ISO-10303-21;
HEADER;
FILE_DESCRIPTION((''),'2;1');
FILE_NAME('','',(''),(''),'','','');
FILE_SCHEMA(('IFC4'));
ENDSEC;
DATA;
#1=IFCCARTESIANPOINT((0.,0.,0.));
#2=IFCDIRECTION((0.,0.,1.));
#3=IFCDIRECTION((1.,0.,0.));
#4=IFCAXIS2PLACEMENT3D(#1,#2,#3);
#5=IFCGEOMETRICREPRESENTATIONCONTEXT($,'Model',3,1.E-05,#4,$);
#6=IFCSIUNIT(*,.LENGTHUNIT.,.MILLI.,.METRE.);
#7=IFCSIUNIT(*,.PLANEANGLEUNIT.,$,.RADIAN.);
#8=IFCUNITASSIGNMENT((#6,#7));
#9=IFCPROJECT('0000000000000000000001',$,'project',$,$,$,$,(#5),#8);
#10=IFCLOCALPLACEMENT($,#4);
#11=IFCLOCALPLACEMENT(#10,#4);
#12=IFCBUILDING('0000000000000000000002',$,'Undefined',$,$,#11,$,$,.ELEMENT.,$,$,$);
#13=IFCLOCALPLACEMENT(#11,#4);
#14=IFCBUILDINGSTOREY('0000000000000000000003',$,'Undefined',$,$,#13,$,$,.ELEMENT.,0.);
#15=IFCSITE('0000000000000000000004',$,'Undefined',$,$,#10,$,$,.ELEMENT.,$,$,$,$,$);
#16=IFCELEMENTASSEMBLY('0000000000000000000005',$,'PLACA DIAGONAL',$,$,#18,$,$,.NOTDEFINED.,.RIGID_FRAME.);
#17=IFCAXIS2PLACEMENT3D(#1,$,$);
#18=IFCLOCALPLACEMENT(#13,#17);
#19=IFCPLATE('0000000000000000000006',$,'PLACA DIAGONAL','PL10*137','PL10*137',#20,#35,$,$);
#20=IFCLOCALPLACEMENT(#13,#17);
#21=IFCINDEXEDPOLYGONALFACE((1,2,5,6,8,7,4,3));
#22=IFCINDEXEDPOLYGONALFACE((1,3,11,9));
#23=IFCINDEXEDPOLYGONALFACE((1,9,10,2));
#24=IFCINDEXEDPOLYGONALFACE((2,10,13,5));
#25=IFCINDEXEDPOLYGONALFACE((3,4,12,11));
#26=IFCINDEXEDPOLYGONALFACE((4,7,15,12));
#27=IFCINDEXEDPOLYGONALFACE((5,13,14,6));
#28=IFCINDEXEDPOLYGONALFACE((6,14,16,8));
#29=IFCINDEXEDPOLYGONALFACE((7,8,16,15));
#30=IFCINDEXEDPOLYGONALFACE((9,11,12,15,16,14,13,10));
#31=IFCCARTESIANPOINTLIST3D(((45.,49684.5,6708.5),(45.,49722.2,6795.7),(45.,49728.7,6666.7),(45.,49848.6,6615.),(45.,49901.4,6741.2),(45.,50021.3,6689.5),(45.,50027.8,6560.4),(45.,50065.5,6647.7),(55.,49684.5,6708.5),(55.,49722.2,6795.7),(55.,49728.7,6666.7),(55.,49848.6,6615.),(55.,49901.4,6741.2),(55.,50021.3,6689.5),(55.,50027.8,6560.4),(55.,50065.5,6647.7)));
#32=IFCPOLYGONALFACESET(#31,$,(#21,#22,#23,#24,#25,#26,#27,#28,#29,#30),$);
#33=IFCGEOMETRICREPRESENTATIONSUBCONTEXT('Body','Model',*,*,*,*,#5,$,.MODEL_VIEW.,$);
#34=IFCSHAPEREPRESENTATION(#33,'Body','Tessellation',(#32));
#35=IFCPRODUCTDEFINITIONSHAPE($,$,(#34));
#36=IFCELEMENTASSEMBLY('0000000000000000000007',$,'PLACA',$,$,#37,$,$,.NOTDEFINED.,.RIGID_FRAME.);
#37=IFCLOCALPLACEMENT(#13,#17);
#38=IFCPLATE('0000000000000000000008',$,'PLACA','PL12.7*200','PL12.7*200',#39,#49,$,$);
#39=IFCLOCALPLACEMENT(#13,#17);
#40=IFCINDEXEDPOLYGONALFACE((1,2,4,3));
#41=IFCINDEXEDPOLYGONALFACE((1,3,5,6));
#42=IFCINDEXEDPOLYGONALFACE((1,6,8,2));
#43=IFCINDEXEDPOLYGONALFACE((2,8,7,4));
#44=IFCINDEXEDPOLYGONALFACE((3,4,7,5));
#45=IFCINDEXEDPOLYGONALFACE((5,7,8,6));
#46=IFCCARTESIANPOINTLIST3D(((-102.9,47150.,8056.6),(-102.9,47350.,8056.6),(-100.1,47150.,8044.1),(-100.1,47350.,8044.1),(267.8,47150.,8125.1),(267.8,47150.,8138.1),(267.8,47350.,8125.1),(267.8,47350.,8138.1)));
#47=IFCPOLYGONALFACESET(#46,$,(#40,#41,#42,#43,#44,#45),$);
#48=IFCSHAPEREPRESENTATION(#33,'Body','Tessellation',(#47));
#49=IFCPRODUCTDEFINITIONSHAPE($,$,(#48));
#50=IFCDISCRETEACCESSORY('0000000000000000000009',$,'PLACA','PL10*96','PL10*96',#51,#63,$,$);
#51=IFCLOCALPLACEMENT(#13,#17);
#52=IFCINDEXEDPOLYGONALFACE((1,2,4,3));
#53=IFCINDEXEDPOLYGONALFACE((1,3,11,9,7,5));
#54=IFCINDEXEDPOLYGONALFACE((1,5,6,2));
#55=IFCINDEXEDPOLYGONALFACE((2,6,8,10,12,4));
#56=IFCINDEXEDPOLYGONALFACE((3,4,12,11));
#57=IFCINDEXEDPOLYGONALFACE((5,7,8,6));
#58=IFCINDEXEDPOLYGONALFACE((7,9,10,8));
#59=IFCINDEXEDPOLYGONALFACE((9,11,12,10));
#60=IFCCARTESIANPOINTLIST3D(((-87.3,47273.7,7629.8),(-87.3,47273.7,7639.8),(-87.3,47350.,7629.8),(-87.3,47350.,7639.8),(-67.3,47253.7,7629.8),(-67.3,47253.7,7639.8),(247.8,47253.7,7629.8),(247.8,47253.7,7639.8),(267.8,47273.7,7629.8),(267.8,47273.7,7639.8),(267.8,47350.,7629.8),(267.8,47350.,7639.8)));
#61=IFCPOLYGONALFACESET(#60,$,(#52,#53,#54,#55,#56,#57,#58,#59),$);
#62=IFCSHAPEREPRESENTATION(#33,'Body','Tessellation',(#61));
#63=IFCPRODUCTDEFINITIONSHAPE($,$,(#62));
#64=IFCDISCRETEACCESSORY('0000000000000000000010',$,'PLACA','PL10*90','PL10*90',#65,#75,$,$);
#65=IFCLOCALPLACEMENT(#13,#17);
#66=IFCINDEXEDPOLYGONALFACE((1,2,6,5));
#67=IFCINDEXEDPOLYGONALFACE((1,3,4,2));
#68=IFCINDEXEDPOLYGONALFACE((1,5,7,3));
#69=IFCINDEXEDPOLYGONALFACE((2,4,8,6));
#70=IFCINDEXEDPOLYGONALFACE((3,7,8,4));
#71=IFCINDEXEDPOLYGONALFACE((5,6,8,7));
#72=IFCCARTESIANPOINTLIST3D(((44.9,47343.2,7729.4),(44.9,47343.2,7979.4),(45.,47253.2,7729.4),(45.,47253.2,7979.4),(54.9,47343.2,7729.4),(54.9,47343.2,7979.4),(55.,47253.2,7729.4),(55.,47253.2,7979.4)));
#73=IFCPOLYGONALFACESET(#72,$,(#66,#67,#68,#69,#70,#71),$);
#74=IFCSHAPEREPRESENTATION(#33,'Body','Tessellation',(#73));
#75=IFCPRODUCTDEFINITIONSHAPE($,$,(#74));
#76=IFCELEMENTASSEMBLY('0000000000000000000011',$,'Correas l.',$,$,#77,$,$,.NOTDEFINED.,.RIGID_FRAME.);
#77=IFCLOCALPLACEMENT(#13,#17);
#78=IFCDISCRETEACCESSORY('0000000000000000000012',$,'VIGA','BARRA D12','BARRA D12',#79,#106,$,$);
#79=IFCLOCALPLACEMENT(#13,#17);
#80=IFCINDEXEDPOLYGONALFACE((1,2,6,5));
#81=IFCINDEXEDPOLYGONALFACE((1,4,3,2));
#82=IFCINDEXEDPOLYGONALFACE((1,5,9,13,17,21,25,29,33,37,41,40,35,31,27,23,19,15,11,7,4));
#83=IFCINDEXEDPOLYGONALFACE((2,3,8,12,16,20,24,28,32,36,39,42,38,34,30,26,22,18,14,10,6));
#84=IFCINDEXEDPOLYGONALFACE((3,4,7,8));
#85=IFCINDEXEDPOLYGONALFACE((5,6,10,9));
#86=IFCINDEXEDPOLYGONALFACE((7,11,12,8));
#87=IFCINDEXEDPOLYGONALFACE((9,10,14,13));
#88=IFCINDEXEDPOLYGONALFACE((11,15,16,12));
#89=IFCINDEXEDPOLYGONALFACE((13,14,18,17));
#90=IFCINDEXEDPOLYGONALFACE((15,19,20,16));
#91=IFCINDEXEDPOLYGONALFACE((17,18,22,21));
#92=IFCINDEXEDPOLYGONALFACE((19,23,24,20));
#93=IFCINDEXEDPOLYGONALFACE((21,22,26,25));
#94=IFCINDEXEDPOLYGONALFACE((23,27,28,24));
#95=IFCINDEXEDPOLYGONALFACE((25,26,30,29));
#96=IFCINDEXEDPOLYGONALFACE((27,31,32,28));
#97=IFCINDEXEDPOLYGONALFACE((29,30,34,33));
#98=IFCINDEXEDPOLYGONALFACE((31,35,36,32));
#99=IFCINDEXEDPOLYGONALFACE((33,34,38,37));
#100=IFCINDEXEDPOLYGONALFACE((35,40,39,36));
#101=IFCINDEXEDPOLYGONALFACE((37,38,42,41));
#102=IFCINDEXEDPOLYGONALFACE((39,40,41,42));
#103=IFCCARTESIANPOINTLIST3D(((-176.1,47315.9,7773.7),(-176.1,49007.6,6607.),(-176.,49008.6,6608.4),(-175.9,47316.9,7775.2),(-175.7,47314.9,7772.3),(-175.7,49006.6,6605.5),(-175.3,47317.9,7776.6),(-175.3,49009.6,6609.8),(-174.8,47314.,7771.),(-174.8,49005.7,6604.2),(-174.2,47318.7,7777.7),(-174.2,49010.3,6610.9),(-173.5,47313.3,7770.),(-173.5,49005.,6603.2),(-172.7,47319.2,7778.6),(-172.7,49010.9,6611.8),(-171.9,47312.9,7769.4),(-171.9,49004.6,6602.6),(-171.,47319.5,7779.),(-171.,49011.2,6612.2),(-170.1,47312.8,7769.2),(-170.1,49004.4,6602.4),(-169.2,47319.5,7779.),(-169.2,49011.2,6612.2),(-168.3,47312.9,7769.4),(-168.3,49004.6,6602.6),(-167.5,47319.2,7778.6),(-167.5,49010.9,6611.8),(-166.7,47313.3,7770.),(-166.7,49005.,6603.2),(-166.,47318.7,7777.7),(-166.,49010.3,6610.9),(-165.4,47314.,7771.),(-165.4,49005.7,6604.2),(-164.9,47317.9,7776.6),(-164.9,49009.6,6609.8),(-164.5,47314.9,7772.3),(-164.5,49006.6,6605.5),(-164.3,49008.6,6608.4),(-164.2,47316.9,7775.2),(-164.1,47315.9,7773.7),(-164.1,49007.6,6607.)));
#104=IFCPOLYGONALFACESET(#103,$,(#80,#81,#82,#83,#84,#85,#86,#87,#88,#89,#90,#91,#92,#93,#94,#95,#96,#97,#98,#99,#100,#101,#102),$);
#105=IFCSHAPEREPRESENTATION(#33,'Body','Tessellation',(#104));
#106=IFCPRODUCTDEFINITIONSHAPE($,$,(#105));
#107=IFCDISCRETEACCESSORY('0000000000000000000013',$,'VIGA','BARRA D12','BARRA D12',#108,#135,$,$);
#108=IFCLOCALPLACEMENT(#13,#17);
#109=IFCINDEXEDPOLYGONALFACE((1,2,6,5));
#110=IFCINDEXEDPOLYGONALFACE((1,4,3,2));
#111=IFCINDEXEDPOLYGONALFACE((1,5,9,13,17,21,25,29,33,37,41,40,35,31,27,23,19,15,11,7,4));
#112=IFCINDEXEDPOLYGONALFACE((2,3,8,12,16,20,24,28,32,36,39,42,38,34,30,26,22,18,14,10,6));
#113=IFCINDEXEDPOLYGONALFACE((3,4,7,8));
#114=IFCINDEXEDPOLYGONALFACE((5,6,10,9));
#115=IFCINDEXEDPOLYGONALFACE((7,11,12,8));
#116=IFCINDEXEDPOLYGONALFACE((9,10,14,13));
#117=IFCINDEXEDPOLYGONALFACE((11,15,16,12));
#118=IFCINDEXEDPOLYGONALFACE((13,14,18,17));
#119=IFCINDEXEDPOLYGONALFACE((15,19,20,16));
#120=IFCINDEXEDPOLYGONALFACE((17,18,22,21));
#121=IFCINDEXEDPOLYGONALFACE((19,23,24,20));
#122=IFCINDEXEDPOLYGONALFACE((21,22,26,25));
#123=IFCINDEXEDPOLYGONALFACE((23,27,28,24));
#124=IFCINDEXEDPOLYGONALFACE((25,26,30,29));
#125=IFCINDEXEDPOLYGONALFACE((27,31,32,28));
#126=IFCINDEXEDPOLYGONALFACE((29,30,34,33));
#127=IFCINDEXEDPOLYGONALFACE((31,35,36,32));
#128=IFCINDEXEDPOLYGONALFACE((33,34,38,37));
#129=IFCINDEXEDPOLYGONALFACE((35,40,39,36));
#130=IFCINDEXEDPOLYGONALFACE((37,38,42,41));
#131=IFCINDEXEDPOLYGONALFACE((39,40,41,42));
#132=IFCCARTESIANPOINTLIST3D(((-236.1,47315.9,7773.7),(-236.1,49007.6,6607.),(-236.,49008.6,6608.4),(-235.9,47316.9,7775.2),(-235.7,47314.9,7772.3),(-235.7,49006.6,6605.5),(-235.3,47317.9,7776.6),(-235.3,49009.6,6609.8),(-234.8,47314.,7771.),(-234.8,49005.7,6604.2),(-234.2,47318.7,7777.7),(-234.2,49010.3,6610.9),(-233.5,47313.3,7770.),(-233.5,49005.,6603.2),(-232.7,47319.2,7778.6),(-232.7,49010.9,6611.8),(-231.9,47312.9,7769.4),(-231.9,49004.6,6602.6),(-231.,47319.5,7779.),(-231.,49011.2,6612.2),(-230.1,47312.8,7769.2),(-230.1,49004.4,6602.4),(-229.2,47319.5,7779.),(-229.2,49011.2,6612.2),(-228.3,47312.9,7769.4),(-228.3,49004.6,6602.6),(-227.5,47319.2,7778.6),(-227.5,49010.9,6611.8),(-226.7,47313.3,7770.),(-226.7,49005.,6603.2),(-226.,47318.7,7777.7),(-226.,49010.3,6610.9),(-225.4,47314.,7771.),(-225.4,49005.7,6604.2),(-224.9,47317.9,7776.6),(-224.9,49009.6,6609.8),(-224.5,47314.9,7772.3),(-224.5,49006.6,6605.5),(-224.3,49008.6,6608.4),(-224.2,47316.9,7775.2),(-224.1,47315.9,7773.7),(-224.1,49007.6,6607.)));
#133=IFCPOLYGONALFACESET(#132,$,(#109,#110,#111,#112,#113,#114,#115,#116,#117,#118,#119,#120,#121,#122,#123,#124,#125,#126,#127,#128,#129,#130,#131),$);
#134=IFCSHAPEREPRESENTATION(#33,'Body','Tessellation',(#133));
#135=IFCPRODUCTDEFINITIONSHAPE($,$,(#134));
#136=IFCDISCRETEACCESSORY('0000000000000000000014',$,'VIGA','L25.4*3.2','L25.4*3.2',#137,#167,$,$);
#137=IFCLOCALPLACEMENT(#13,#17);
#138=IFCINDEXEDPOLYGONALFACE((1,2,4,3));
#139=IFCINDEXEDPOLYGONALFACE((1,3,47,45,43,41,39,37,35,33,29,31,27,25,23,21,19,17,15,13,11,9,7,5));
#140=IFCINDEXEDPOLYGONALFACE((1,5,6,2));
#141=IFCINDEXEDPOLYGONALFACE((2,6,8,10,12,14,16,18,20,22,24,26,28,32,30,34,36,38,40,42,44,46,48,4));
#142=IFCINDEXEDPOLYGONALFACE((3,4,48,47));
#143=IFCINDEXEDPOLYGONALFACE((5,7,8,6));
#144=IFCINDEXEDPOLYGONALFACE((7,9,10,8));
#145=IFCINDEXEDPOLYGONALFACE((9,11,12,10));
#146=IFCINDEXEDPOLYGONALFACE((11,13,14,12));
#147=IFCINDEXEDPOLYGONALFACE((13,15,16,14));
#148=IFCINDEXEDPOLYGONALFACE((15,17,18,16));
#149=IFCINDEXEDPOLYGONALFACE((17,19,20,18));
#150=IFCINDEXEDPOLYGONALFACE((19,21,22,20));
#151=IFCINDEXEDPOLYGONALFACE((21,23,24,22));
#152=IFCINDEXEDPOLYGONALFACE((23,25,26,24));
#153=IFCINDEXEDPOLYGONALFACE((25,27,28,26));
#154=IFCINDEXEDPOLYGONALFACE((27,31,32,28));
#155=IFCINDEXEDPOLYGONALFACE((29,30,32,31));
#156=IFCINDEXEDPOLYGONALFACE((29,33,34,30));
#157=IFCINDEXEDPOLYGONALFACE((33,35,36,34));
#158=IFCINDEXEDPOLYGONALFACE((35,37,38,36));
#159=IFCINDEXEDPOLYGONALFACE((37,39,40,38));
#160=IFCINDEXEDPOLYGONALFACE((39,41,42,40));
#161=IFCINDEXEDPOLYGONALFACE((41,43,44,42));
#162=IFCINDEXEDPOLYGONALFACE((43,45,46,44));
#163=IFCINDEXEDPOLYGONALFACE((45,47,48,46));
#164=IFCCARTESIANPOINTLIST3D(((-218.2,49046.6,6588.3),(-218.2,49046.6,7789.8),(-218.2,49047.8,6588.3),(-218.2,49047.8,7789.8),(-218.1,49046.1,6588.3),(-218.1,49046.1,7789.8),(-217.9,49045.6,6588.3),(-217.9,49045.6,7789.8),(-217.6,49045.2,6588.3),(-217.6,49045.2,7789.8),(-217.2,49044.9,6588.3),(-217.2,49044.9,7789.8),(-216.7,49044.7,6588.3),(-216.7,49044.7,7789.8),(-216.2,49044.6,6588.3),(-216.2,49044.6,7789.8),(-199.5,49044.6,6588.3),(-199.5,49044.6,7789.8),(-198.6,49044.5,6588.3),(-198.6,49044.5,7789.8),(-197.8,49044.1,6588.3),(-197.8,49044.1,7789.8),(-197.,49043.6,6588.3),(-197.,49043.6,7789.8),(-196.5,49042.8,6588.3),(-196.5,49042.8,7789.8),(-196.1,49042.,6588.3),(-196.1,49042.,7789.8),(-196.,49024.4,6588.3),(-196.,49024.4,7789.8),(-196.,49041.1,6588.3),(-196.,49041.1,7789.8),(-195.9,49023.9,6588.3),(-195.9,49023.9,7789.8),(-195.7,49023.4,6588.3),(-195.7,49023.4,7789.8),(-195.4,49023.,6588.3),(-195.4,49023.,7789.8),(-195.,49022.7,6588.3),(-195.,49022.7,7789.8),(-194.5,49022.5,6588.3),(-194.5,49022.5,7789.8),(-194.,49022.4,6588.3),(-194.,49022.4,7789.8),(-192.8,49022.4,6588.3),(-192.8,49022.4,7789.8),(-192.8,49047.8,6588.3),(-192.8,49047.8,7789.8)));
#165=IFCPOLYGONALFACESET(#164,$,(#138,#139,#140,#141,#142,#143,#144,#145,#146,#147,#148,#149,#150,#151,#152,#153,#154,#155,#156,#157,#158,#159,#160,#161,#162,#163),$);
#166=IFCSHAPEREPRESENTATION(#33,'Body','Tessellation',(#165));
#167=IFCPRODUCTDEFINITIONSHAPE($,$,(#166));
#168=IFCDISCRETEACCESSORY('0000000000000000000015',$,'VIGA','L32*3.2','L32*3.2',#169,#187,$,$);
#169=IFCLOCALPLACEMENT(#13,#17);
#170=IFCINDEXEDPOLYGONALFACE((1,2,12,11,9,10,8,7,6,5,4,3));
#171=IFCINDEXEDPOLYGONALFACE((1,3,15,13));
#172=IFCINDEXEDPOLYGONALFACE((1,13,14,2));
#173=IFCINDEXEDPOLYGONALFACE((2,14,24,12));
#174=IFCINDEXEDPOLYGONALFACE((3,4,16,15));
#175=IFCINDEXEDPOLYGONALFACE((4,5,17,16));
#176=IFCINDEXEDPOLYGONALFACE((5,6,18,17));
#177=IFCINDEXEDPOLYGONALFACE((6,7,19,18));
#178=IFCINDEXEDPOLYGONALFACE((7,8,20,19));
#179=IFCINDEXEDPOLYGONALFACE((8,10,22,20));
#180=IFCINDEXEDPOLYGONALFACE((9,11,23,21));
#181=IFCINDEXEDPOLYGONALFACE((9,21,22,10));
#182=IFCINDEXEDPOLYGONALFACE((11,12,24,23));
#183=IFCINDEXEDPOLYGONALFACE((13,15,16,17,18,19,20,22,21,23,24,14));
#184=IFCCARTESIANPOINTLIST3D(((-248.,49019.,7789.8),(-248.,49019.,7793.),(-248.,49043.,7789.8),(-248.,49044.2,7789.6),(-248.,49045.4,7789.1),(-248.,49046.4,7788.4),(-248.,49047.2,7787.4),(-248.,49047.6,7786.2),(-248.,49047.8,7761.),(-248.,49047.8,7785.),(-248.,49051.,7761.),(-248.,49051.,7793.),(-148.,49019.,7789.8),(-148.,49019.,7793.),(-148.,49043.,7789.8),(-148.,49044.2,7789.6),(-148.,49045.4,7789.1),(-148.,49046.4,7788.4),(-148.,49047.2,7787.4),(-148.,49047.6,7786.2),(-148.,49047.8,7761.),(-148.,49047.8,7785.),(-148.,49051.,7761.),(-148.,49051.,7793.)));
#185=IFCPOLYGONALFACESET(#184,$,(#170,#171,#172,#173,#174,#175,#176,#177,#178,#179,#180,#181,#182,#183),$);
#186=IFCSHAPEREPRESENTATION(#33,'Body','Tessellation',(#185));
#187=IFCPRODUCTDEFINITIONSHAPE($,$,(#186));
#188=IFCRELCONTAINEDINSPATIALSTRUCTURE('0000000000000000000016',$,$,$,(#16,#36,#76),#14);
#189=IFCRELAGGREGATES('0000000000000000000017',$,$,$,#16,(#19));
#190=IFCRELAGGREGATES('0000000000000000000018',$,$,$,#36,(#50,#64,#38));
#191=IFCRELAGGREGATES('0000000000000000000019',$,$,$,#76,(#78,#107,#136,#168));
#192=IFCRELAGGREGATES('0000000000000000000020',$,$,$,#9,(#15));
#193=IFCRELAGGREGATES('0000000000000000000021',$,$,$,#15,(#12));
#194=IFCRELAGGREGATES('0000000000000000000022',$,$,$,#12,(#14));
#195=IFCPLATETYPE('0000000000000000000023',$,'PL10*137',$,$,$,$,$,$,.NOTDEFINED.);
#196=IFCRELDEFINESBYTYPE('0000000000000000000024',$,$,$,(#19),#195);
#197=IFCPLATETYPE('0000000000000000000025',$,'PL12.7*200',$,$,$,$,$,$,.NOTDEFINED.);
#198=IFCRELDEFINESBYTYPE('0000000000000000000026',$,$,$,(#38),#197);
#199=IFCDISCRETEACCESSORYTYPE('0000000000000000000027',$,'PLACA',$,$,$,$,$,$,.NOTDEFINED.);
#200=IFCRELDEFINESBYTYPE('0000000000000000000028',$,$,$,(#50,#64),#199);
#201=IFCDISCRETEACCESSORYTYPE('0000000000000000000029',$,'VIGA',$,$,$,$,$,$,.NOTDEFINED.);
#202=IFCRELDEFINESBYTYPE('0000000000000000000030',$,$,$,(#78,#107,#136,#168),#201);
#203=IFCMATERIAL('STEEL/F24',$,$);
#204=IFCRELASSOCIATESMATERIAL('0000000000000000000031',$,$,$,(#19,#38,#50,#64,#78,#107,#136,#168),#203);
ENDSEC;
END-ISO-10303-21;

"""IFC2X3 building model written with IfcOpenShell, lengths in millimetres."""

from ifc_helpers import new_model, si_unit, frame, origin_with_axes, origin_2d_with_axis, place, context, subcontext, project, spatial, polyline, circle, l_section, outline, extrude, clip, halfspace, material, type_object, element, aggregate, save


model = new_model("IFC2X3")

# Units and contexts
model_context = context("Model", 3, precision=1e-05, world=origin_with_axes())
body_context = subcontext(model_context, "Body", "Model", "MODEL_VIEW")
ifc_project = project(units=[si_unit("LENGTHUNIT", "METRE", prefix="MILLI"), si_unit("PLANEANGLEUNIT", "RADIAN")], contexts=[model_context])

# Site, building, storey
site_placement = place(None, origin_with_axes())
site = spatial("IfcSite", under=ifc_project, at=site_placement, Name="Undefined", CompositionType="ELEMENT")
building_placement = place(site_placement, origin_with_axes())
building = spatial("IfcBuilding", under=site, at=building_placement, Name="Undefined", CompositionType="ELEMENT")
storey_placement = place(building_placement, origin_with_axes())
storey = spatial("IfcBuildingStorey", under=building, at=storey_placement, Name="Undefined", CompositionType="ELEMENT", Elevation=0.0)

# Element assembly, plate
assembly_1_placement = place(storey_placement, origin_with_axes())
assembly_1 = element("IfcElementAssembly", 1, at=assembly_1_placement, inside=storey, Name="PLACA DIAGONAL", AssemblyPlace="NOTDEFINED", PredefinedType="RIGID_FRAME")
ifc_material_1 = material(Name="STEEL/F24")
plate_type_1 = type_object("IfcPlateType", Name="PL10*137", PredefinedType="NOTDEFINED")
plate_1_placement = place(assembly_1_placement, frame((50.0, 50021.3, 6689.5), z_axis=(-1.0, -0.00001, 0.0), x_axis=(-0.000008, 0.725994, -0.687701)))
plate_1 = element("IfcPlate", 2, at=plate_1_placement, type_object=plate_type_1, material=ifc_material_1, Name="PLACA DIAGONAL", Description="PL10*137", ObjectType="PL10*137", context=body_context, shape_type="SweptSolid", body=[
    extrude(outline(polyline([(0.0, 0.0), (60.8, 0.0), (93.5, 89.2), (-74.2, 172.9), (-196.8, 217.8), (-257.6, 217.8), (-290.3, 128.6), (-122.6, 44.9), (0.0, 0.0)])), frame((0.0, 0.0, -5.0), z_axis=(0.0, 0.0, 1.0), x_axis=(1.0, 0.0, 0.0)), (0.0, 0.0, 1.0), 10.0),
])
aggregate(assembly_1, [plate_1])

# Element assembly, plate, discrete accessories
assembly_2_placement = place(storey_placement, origin_with_axes())
assembly_2 = element("IfcElementAssembly", 3, at=assembly_2_placement, inside=storey, Name="PLACA", AssemblyPlace="NOTDEFINED", PredefinedType="RIGID_FRAME")
plate_type_2 = type_object("IfcPlateType", Name="PL12.7*200", PredefinedType="NOTDEFINED")
plate_2_placement = place(assembly_2_placement, frame((-101.5, 47350.0, 8050.3), z_axis=(0.214887, 0.0, -0.976639), x_axis=(0.976639, 0.0, 0.214887)))
plate_2 = element("IfcPlate", 4, at=plate_2_placement, type_object=plate_type_2, material=ifc_material_1, Name="PLACA", Description="PL12.7*200", ObjectType="PL12.7*200", context=body_context, shape_type="Clipping", body=[
    clip(extrude(outline(polyline([(0.0, 0.0), (593.2, 0.0), (593.2, 200.0), (0.0, 200.0), (0.0, 0.0)])), frame((0.0, 0.0, -6.3), z_axis=(0.0, 0.0, 1.0), x_axis=(1.0, 0.0, 0.0)), (0.0, 0.0, 1.0), 12.7), halfspace(frame((379.5, 500.0, -6.4), z_axis=(0.976639, 0.0, 0.214886), x_axis=(0.0, -1.0, 0.0)), False)),
])
discrete_accessory_type_1 = type_object("IfcDiscreteAccessoryType", Name="PLACA")
discrete_accessory_1_placement = place(assembly_2_placement, frame((-87.3, 47253.7, 7634.8), z_axis=(0.0, 0.0, 1.0), x_axis=(1.0, 0.0, 0.0)))
discrete_accessory_1 = element("IfcDiscreteAccessory", 5, at=discrete_accessory_1_placement, type_object=discrete_accessory_type_1, material=ifc_material_1, Name="PLACA", Description="PL10*96", ObjectType="PL10*96", context=body_context, shape_type="SweptSolid", body=[
    extrude(outline(polyline([(0.0, 20.0), (20.0, 0.0), (335.1, 0.0), (355.1, 20.0), (355.1, 96.3), (0.0, 96.3), (0.0, 20.0)])), frame((0.0, 0.0, -5.0), z_axis=(0.0, 0.0, 1.0), x_axis=(1.0, 0.0, 0.0)), (0.0, 0.0, 1.0), 10.0),
])
discrete_accessory_2_placement = place(assembly_2_placement, frame((49.9, 47343.2, 7729.4), z_axis=(-1.0, -0.000594, -0.000001), x_axis=(0.000594, -1.0, 0.000002)))
discrete_accessory_2 = element("IfcDiscreteAccessory", 6, at=discrete_accessory_2_placement, type_object=discrete_accessory_type_1, material=ifc_material_1, Name="PLACA", Description="PL10*90", ObjectType="PL10*90", context=body_context, shape_type="SweptSolid", body=[
    extrude(outline(polyline([(0.0, 0.0), (90.0, 0.0), (90.0, 250.0), (0.0, 250.0), (0.0, 0.0)])), frame((0.0, 0.0, -5.0), z_axis=(0.0, 0.0, 1.0), x_axis=(1.0, 0.0, 0.0)), (0.0, 0.0, 1.0), 10.0),
])
aggregate(assembly_2, [discrete_accessory_1, discrete_accessory_2, plate_2])

# Element assembly, discrete accessories
assembly_3_placement = place(storey_placement, origin_with_axes())
assembly_3 = element("IfcElementAssembly", 7, at=assembly_3_placement, inside=storey, Name="Correas l.", AssemblyPlace="NOTDEFINED", PredefinedType="RIGID_FRAME")
discrete_accessory_type_2 = type_object("IfcDiscreteAccessoryType", Name="VIGA")
discrete_accessory_3_placement = place(assembly_3_placement, frame((-170.1, 49007.8, 6607.3), z_axis=(-1.0, -0.00001, 0.0), x_axis=(0.000008, -0.823189, 0.567767)))
discrete_accessory_3 = element("IfcDiscreteAccessory", 8, at=discrete_accessory_3_placement, type_object=discrete_accessory_type_2, material=ifc_material_1, Name="VIGA", Description="BARRA D12", ObjectType="BARRA D12", context=body_context, shape_type="SweptSolid", body=[
    extrude(circle(Radius=6.0, at=origin_2d_with_axis()), frame((2055.0, 0.0, 0.0), z_axis=(-1.0, 0.0, 0.0), x_axis=(0.0, -1.0, 0.0)), (0.0, 0.0, 1.0), 2055.0),
])
discrete_accessory_4_placement = place(assembly_3_placement, frame((-230.1, 49007.8, 6607.3), z_axis=(-1.0, -0.00001, 0.0), x_axis=(0.000008, -0.823189, 0.567767)))
discrete_accessory_4 = element("IfcDiscreteAccessory", 9, at=discrete_accessory_4_placement, type_object=discrete_accessory_type_2, material=ifc_material_1, Name="VIGA", Description="BARRA D12", ObjectType="BARRA D12", context=body_context, shape_type="SweptSolid", body=[
    extrude(circle(Radius=6.0, at=origin_2d_with_axis()), frame((2055.0, 0.0, 0.0), z_axis=(-1.0, 0.0, 0.0), x_axis=(0.0, -1.0, 0.0)), (0.0, 0.0, 1.0), 2055.0),
])
discrete_accessory_5_placement = place(assembly_3_placement, frame((-205.5, 49035.1, 7789.8), z_axis=(0.0, -1.0, 0.0), x_axis=(0.0, 0.0, -1.0)))
discrete_accessory_5 = element("IfcDiscreteAccessory", 10, at=discrete_accessory_5_placement, type_object=discrete_accessory_type_2, material=ifc_material_1, Name="VIGA", Description="L25.4*3.2", ObjectType="L25.4*3.2", context=body_context, shape_type="SweptSolid", body=[
    extrude(l_section(Depth=25.4, Width=25.4, Thickness=3.2, FilletRadius=3.5, EdgeRadius=2.0, at=origin_2d_with_axis()), frame((1201.4, 0.0, 0.0), z_axis=(-1.0, 0.0, 0.0), x_axis=(0.0, -1.0, 0.0)), (0.0, 0.0, 1.0), 1201.4),
])
discrete_accessory_6_placement = place(assembly_3_placement, frame((-248.0, 49035.0, 7777.0), z_axis=(0.0, -1.0, 0.0), x_axis=(1.0, 0.0, 0.0)))
discrete_accessory_6 = element("IfcDiscreteAccessory", 11, at=discrete_accessory_6_placement, type_object=discrete_accessory_type_2, material=ifc_material_1, Name="VIGA", Description="L32*3.2", ObjectType="L32*3.2", context=body_context, shape_type="SweptSolid", body=[
    extrude(l_section(Depth=32.0, Width=32.0, Thickness=3.2, FilletRadius=4.8, at=origin_2d_with_axis()), frame((100.0, 0.0, 0.0), z_axis=(-1.0, 0.0, 0.0), x_axis=(0.0, -1.0, 0.0)), (0.0, 0.0, 1.0), 100.0),
])

aggregate(assembly_3, [discrete_accessory_3, discrete_accessory_4, discrete_accessory_5, discrete_accessory_6])

save(model, "model.ifc")
